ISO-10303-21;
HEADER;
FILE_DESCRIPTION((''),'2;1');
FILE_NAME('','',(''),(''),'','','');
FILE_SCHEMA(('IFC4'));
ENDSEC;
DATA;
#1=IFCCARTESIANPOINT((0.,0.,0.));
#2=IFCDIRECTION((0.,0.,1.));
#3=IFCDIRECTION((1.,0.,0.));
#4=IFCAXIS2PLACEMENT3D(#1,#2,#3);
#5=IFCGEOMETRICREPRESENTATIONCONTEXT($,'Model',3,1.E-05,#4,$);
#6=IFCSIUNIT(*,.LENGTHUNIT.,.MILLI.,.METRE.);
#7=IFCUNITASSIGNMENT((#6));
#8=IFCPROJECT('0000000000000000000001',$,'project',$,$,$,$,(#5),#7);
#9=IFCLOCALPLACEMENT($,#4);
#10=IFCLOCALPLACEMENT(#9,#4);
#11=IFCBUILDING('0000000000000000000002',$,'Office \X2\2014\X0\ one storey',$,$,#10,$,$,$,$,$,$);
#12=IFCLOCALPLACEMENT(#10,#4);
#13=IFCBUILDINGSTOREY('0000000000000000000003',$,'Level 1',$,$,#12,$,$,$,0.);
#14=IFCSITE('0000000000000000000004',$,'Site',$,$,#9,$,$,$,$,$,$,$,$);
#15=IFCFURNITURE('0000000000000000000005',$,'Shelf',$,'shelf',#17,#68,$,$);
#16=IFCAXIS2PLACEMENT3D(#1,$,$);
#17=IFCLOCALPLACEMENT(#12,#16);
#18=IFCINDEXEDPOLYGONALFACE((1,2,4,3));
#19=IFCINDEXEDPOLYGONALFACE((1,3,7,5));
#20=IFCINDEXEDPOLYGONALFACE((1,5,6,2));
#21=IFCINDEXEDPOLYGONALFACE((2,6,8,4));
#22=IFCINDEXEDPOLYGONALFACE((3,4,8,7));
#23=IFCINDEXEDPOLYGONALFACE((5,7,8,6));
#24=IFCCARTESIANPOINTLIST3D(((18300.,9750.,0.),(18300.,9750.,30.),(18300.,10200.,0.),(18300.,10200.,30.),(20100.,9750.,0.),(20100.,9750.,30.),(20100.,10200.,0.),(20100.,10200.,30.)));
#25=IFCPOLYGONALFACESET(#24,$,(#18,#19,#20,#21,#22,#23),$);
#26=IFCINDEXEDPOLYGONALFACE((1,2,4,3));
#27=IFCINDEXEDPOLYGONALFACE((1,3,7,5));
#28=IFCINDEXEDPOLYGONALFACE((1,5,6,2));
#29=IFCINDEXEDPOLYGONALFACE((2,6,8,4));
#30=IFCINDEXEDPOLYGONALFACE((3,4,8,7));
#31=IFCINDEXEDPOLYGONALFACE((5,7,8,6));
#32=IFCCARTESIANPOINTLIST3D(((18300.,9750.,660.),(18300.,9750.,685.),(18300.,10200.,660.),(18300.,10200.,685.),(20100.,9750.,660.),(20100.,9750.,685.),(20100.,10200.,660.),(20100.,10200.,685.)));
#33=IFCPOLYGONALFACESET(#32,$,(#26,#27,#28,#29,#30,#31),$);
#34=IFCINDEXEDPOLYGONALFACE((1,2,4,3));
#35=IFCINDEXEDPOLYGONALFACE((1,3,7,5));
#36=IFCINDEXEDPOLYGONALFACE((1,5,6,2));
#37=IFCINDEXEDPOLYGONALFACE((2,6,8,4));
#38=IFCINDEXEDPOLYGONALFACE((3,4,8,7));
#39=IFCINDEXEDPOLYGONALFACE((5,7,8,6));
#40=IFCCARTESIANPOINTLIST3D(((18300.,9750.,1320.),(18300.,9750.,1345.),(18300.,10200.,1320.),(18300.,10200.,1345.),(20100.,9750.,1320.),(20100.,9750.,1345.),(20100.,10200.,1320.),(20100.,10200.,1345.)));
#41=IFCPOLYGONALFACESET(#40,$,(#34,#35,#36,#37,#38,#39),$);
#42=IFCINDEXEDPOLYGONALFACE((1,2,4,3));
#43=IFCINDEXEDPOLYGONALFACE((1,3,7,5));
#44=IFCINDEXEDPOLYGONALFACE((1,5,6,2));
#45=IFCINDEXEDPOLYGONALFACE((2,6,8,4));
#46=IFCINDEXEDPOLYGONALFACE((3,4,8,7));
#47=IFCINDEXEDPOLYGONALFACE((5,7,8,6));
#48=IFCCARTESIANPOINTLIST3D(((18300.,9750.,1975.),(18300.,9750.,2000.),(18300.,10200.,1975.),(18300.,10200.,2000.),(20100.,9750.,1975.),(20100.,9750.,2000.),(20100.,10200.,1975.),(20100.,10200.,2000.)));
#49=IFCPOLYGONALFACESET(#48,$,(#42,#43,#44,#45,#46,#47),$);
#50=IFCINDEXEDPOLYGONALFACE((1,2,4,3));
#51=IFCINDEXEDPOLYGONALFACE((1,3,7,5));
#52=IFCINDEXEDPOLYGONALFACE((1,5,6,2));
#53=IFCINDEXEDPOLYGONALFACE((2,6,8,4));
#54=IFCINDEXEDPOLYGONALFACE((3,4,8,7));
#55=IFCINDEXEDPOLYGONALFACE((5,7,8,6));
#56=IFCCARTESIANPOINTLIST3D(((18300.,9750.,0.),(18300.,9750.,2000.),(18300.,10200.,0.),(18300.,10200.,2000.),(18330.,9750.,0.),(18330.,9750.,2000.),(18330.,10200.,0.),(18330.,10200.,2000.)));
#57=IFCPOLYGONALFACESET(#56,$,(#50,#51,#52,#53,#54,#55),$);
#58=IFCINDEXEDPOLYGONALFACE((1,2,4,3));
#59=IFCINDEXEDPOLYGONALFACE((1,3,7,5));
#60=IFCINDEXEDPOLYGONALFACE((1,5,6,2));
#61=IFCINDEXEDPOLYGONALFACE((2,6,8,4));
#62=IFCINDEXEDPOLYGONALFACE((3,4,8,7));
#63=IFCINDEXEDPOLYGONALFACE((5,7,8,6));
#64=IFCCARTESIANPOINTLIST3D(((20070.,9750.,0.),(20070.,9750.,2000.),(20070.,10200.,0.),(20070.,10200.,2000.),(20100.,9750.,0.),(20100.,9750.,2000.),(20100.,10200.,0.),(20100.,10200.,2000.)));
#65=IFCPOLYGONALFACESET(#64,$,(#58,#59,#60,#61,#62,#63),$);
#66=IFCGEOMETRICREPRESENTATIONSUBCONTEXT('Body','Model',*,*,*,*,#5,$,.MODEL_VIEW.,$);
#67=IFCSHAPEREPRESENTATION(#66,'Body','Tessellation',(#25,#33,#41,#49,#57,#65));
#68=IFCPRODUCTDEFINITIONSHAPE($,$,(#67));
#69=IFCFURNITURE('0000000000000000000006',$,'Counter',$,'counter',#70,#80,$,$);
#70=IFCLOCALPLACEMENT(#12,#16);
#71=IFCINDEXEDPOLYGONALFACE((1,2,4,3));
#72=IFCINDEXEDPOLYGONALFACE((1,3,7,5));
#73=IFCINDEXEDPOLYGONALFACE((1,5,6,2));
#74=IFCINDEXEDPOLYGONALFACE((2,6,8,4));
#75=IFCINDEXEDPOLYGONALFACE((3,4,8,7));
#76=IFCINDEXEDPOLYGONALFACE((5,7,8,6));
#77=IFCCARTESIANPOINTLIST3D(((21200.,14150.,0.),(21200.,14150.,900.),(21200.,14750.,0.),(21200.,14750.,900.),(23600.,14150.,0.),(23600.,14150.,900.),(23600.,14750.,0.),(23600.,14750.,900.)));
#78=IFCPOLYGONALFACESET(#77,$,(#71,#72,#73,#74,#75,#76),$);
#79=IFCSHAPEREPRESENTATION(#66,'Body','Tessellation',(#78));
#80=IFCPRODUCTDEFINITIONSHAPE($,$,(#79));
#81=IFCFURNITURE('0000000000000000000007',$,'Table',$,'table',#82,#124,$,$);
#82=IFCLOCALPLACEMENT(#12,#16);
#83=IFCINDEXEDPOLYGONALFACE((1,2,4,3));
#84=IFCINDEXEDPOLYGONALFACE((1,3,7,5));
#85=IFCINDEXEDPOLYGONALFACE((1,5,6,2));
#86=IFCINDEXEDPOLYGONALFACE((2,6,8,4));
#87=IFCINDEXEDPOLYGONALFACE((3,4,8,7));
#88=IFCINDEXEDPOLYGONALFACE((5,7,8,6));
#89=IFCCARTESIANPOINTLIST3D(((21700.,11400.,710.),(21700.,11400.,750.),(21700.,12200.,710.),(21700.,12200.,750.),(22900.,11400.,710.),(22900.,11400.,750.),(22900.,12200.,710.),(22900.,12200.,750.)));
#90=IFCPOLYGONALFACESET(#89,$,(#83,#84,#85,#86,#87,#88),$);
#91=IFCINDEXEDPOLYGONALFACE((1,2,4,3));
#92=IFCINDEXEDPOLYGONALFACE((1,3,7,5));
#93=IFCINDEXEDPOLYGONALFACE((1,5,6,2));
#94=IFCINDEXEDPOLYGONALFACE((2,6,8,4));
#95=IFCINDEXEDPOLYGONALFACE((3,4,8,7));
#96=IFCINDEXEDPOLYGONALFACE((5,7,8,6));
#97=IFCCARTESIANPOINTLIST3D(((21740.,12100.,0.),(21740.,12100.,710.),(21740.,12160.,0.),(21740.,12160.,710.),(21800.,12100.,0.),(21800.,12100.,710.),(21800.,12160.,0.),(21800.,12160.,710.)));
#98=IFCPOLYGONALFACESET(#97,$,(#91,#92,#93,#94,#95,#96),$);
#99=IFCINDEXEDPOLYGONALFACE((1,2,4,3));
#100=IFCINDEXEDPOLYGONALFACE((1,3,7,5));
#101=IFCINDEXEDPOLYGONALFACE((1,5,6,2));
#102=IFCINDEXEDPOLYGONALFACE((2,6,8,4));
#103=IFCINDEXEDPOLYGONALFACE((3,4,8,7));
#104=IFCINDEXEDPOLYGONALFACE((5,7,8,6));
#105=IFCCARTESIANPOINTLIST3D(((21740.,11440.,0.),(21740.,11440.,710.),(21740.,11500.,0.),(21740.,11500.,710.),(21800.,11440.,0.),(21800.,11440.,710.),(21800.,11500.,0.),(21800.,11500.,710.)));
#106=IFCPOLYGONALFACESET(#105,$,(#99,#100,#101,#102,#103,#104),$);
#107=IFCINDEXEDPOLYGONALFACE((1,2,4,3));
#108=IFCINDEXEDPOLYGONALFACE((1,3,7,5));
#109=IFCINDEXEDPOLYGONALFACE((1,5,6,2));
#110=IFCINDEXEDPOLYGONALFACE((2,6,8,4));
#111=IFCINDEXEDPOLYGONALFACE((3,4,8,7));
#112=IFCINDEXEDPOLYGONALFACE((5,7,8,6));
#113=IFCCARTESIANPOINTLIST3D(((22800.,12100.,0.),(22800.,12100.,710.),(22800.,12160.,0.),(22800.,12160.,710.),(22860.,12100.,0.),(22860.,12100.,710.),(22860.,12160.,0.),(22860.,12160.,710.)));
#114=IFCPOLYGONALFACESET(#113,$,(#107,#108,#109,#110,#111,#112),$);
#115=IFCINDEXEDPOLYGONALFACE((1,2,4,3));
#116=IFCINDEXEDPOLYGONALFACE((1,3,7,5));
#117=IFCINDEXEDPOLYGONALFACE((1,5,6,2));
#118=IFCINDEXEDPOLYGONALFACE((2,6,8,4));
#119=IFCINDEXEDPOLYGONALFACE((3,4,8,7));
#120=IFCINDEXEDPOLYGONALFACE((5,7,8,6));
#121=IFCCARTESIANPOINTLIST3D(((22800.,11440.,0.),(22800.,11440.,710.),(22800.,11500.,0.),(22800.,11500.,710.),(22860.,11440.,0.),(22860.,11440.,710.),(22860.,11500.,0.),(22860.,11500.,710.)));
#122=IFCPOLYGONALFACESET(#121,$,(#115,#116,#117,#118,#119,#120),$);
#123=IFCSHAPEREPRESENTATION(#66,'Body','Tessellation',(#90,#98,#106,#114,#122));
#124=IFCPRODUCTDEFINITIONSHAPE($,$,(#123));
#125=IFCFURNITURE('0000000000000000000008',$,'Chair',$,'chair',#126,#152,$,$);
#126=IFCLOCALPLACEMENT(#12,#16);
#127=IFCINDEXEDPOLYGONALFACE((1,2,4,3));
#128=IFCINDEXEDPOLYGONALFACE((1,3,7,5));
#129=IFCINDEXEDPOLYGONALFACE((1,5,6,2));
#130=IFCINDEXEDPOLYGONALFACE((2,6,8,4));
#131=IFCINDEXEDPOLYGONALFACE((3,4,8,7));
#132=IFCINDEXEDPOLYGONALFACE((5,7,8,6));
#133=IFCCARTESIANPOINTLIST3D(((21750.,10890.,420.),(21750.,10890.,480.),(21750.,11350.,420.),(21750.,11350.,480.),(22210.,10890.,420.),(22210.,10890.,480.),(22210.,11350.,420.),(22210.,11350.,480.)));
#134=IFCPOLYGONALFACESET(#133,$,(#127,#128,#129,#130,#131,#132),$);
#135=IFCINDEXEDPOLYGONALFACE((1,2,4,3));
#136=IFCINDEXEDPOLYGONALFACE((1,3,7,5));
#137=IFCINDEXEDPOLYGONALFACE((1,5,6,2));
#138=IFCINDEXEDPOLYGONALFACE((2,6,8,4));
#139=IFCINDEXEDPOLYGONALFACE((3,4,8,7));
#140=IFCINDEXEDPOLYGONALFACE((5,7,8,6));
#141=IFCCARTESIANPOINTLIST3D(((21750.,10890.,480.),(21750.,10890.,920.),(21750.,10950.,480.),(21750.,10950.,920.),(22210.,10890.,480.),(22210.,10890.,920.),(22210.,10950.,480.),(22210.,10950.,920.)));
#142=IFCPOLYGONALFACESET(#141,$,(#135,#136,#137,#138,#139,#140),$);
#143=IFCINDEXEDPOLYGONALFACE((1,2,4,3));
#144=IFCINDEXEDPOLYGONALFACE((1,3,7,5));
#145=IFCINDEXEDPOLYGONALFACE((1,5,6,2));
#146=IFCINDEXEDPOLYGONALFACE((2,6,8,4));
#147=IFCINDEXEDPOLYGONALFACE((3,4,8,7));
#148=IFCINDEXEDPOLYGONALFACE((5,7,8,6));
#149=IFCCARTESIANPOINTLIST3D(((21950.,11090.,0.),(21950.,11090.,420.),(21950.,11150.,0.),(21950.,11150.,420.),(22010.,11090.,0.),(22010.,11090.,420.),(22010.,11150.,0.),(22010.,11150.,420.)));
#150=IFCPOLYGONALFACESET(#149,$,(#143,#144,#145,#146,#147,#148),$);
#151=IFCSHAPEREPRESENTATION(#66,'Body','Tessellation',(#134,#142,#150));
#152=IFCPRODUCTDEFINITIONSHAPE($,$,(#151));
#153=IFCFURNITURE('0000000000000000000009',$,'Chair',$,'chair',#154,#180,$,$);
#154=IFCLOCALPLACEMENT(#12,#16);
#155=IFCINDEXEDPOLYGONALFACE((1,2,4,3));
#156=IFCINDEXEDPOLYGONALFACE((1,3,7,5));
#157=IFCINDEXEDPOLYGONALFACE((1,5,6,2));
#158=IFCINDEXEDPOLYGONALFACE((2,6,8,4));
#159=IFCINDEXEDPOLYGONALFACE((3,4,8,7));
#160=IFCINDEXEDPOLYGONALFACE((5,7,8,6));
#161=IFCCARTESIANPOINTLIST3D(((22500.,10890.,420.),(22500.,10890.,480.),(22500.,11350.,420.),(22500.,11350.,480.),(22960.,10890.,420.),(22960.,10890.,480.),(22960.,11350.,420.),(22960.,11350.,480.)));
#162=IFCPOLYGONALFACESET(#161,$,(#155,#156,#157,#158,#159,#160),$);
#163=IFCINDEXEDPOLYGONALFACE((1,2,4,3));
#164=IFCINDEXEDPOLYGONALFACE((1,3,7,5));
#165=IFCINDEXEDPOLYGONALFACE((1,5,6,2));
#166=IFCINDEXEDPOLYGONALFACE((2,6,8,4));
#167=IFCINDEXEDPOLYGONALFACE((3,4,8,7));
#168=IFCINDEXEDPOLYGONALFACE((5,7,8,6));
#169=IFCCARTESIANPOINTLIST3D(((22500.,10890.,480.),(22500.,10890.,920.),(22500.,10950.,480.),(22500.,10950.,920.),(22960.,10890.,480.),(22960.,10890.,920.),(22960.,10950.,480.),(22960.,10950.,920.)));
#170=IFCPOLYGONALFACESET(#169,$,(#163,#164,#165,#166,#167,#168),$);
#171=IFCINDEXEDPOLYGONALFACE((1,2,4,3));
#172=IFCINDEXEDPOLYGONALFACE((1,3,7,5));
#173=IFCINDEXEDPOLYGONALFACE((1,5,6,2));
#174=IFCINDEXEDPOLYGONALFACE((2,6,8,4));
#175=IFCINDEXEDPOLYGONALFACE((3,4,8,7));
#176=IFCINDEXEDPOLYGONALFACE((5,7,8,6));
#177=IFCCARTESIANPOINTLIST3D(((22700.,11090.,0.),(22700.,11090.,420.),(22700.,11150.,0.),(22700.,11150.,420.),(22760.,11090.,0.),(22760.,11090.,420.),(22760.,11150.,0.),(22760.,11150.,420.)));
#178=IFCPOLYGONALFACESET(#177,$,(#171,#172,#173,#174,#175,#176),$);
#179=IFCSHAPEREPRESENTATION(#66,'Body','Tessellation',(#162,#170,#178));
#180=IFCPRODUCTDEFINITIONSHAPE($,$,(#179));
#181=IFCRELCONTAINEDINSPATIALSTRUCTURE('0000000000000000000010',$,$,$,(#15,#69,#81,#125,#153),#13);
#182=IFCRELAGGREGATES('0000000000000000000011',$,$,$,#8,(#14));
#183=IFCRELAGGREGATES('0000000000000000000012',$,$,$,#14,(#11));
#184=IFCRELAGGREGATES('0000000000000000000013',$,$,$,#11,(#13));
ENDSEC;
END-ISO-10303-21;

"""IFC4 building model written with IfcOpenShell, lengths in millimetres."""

from ifc_helpers import new_model, si_unit, frame, frame_2d, origin, origin_with_axes, place, context, subcontext, project, spatial, rectangle, extrude, element, save


model = new_model("IFC4")

# Units and contexts
model_context = context("Model", 3, precision=1e-05, world=origin_with_axes())
body_context = subcontext(model_context, "Body", "Model", "MODEL_VIEW")
ifc_project = project(units=[si_unit("LENGTHUNIT", "METRE", prefix="MILLI")], contexts=[model_context])

# Site, building, storey
site_placement = place(None, origin_with_axes())
site = spatial("IfcSite", under=ifc_project, at=site_placement, Name="Site")
building_placement = place(site_placement, origin_with_axes())
building = spatial("IfcBuilding", under=site, at=building_placement, Name="Office — one storey")
storey_placement = place(building_placement, origin_with_axes())
storey = spatial("IfcBuildingStorey", under=building, at=storey_placement, Name="Level 1", Elevation=0.0)

# Furniture
for number, where, z_axis, x_axis, name in (
    (1, (18300.0, 9750.0, 0.0), (0.0, 0.0, 1.0), (1.0, 0.0, 0.0), "Shelf"),
):
    element("IfcFurniture", number, at=place(storey_placement, frame(where, z_axis=z_axis, x_axis=x_axis)), inside=storey, Name=name, ObjectType="shelf", context=body_context, shape_type="SweptSolid", body=[
        extrude(rectangle(XDim=1800.0, YDim=450.0, at=frame_2d((900.0, 225.0))), origin(), (0.0, 0.0, 1.0), 30.0),
        extrude(rectangle(XDim=1800.0, YDim=450.0, at=frame_2d((900.0, 225.0))), frame((0.0, 0.0, 660.0)), (0.0, 0.0, 1.0), 25.0),
        extrude(rectangle(XDim=1800.0, YDim=450.0, at=frame_2d((900.0, 225.0))), frame((0.0, 0.0, 1320.0)), (0.0, 0.0, 1.0), 25.0),
        extrude(rectangle(XDim=1800.0, YDim=450.0, at=frame_2d((900.0, 225.0))), frame((0.0, 0.0, 1975.0)), (0.0, 0.0, 1.0), 25.0),
        extrude(rectangle(XDim=30.0, YDim=450.0, at=frame_2d((15.0, 225.0))), origin(), (0.0, 0.0, 1.0), 2000.0),
        extrude(rectangle(XDim=30.0, YDim=450.0, at=frame_2d((1785.0, 225.0))), origin(), (0.0, 0.0, 1.0), 2000.0),
    ])
furniture_1_placement = place(storey_placement, frame((21200.0, 14150.0, 0.0), z_axis=(0.0, 0.0, 1.0), x_axis=(1.0, 0.0, 0.0)))
element("IfcFurniture", 2, at=furniture_1_placement, inside=storey, Name="Counter", ObjectType="counter", context=body_context, shape_type="SweptSolid", body=[
    extrude(rectangle(XDim=2400.0, YDim=600.0, at=frame_2d((1200.0, 300.0))), origin(), (0.0, 0.0, 1.0), 900.0),
])
furniture_2_placement = place(storey_placement, frame((21700.0, 11400.0, 0.0), z_axis=(0.0, 0.0, 1.0), x_axis=(1.0, 0.0, 0.0)))
element("IfcFurniture", 3, at=furniture_2_placement, inside=storey, Name="Table", ObjectType="table", context=body_context, shape_type="SweptSolid", body=[
    extrude(rectangle(XDim=1200.0, YDim=800.0, at=frame_2d((600.0, 400.0))), frame((0.0, 0.0, 710.0)), (0.0, 0.0, 1.0), 40.0),
    extrude(rectangle(XDim=60.0, YDim=60.0, at=frame_2d((70.0, 730.0))), origin(), (0.0, 0.0, 1.0), 710.0),
    extrude(rectangle(XDim=60.0, YDim=60.0, at=frame_2d((70.0, 70.0))), origin(), (0.0, 0.0, 1.0), 710.0),
    extrude(rectangle(XDim=60.0, YDim=60.0, at=frame_2d((1130.0, 730.0))), origin(), (0.0, 0.0, 1.0), 710.0),
    extrude(rectangle(XDim=60.0, YDim=60.0, at=frame_2d((1130.0, 70.0))), origin(), (0.0, 0.0, 1.0), 710.0),
])
for number, where, z_axis, x_axis, name in (
    (4, (21750.0, 10890.0, 0.0), (0.0, 0.0, 1.0), (1.0, 0.0, 0.0), "Chair"),
    (5, (22500.0, 10890.0, 0.0), (0.0, 0.0, 1.0), (1.0, 0.0, 0.0), "Chair"),
):
    element("IfcFurniture", number, at=place(storey_placement, frame(where, z_axis=z_axis, x_axis=x_axis)), inside=storey, Name=name, ObjectType="chair", context=body_context, shape_type="SweptSolid", body=[
        extrude(rectangle(XDim=460.0, YDim=460.0, at=frame_2d((230.0, 230.0))), frame((0.0, 0.0, 420.0)), (0.0, 0.0, 1.0), 60.0),
        extrude(rectangle(XDim=460.0, YDim=60.0, at=frame_2d((230.0, 30.0))), frame((0.0, 0.0, 480.0)), (0.0, 0.0, 1.0), 440.0),
        extrude(rectangle(XDim=60.0, YDim=60.0, at=frame_2d((230.0, 230.0))), origin(), (0.0, 0.0, 1.0), 420.0),
    ])

save(model, "model.ifc")
